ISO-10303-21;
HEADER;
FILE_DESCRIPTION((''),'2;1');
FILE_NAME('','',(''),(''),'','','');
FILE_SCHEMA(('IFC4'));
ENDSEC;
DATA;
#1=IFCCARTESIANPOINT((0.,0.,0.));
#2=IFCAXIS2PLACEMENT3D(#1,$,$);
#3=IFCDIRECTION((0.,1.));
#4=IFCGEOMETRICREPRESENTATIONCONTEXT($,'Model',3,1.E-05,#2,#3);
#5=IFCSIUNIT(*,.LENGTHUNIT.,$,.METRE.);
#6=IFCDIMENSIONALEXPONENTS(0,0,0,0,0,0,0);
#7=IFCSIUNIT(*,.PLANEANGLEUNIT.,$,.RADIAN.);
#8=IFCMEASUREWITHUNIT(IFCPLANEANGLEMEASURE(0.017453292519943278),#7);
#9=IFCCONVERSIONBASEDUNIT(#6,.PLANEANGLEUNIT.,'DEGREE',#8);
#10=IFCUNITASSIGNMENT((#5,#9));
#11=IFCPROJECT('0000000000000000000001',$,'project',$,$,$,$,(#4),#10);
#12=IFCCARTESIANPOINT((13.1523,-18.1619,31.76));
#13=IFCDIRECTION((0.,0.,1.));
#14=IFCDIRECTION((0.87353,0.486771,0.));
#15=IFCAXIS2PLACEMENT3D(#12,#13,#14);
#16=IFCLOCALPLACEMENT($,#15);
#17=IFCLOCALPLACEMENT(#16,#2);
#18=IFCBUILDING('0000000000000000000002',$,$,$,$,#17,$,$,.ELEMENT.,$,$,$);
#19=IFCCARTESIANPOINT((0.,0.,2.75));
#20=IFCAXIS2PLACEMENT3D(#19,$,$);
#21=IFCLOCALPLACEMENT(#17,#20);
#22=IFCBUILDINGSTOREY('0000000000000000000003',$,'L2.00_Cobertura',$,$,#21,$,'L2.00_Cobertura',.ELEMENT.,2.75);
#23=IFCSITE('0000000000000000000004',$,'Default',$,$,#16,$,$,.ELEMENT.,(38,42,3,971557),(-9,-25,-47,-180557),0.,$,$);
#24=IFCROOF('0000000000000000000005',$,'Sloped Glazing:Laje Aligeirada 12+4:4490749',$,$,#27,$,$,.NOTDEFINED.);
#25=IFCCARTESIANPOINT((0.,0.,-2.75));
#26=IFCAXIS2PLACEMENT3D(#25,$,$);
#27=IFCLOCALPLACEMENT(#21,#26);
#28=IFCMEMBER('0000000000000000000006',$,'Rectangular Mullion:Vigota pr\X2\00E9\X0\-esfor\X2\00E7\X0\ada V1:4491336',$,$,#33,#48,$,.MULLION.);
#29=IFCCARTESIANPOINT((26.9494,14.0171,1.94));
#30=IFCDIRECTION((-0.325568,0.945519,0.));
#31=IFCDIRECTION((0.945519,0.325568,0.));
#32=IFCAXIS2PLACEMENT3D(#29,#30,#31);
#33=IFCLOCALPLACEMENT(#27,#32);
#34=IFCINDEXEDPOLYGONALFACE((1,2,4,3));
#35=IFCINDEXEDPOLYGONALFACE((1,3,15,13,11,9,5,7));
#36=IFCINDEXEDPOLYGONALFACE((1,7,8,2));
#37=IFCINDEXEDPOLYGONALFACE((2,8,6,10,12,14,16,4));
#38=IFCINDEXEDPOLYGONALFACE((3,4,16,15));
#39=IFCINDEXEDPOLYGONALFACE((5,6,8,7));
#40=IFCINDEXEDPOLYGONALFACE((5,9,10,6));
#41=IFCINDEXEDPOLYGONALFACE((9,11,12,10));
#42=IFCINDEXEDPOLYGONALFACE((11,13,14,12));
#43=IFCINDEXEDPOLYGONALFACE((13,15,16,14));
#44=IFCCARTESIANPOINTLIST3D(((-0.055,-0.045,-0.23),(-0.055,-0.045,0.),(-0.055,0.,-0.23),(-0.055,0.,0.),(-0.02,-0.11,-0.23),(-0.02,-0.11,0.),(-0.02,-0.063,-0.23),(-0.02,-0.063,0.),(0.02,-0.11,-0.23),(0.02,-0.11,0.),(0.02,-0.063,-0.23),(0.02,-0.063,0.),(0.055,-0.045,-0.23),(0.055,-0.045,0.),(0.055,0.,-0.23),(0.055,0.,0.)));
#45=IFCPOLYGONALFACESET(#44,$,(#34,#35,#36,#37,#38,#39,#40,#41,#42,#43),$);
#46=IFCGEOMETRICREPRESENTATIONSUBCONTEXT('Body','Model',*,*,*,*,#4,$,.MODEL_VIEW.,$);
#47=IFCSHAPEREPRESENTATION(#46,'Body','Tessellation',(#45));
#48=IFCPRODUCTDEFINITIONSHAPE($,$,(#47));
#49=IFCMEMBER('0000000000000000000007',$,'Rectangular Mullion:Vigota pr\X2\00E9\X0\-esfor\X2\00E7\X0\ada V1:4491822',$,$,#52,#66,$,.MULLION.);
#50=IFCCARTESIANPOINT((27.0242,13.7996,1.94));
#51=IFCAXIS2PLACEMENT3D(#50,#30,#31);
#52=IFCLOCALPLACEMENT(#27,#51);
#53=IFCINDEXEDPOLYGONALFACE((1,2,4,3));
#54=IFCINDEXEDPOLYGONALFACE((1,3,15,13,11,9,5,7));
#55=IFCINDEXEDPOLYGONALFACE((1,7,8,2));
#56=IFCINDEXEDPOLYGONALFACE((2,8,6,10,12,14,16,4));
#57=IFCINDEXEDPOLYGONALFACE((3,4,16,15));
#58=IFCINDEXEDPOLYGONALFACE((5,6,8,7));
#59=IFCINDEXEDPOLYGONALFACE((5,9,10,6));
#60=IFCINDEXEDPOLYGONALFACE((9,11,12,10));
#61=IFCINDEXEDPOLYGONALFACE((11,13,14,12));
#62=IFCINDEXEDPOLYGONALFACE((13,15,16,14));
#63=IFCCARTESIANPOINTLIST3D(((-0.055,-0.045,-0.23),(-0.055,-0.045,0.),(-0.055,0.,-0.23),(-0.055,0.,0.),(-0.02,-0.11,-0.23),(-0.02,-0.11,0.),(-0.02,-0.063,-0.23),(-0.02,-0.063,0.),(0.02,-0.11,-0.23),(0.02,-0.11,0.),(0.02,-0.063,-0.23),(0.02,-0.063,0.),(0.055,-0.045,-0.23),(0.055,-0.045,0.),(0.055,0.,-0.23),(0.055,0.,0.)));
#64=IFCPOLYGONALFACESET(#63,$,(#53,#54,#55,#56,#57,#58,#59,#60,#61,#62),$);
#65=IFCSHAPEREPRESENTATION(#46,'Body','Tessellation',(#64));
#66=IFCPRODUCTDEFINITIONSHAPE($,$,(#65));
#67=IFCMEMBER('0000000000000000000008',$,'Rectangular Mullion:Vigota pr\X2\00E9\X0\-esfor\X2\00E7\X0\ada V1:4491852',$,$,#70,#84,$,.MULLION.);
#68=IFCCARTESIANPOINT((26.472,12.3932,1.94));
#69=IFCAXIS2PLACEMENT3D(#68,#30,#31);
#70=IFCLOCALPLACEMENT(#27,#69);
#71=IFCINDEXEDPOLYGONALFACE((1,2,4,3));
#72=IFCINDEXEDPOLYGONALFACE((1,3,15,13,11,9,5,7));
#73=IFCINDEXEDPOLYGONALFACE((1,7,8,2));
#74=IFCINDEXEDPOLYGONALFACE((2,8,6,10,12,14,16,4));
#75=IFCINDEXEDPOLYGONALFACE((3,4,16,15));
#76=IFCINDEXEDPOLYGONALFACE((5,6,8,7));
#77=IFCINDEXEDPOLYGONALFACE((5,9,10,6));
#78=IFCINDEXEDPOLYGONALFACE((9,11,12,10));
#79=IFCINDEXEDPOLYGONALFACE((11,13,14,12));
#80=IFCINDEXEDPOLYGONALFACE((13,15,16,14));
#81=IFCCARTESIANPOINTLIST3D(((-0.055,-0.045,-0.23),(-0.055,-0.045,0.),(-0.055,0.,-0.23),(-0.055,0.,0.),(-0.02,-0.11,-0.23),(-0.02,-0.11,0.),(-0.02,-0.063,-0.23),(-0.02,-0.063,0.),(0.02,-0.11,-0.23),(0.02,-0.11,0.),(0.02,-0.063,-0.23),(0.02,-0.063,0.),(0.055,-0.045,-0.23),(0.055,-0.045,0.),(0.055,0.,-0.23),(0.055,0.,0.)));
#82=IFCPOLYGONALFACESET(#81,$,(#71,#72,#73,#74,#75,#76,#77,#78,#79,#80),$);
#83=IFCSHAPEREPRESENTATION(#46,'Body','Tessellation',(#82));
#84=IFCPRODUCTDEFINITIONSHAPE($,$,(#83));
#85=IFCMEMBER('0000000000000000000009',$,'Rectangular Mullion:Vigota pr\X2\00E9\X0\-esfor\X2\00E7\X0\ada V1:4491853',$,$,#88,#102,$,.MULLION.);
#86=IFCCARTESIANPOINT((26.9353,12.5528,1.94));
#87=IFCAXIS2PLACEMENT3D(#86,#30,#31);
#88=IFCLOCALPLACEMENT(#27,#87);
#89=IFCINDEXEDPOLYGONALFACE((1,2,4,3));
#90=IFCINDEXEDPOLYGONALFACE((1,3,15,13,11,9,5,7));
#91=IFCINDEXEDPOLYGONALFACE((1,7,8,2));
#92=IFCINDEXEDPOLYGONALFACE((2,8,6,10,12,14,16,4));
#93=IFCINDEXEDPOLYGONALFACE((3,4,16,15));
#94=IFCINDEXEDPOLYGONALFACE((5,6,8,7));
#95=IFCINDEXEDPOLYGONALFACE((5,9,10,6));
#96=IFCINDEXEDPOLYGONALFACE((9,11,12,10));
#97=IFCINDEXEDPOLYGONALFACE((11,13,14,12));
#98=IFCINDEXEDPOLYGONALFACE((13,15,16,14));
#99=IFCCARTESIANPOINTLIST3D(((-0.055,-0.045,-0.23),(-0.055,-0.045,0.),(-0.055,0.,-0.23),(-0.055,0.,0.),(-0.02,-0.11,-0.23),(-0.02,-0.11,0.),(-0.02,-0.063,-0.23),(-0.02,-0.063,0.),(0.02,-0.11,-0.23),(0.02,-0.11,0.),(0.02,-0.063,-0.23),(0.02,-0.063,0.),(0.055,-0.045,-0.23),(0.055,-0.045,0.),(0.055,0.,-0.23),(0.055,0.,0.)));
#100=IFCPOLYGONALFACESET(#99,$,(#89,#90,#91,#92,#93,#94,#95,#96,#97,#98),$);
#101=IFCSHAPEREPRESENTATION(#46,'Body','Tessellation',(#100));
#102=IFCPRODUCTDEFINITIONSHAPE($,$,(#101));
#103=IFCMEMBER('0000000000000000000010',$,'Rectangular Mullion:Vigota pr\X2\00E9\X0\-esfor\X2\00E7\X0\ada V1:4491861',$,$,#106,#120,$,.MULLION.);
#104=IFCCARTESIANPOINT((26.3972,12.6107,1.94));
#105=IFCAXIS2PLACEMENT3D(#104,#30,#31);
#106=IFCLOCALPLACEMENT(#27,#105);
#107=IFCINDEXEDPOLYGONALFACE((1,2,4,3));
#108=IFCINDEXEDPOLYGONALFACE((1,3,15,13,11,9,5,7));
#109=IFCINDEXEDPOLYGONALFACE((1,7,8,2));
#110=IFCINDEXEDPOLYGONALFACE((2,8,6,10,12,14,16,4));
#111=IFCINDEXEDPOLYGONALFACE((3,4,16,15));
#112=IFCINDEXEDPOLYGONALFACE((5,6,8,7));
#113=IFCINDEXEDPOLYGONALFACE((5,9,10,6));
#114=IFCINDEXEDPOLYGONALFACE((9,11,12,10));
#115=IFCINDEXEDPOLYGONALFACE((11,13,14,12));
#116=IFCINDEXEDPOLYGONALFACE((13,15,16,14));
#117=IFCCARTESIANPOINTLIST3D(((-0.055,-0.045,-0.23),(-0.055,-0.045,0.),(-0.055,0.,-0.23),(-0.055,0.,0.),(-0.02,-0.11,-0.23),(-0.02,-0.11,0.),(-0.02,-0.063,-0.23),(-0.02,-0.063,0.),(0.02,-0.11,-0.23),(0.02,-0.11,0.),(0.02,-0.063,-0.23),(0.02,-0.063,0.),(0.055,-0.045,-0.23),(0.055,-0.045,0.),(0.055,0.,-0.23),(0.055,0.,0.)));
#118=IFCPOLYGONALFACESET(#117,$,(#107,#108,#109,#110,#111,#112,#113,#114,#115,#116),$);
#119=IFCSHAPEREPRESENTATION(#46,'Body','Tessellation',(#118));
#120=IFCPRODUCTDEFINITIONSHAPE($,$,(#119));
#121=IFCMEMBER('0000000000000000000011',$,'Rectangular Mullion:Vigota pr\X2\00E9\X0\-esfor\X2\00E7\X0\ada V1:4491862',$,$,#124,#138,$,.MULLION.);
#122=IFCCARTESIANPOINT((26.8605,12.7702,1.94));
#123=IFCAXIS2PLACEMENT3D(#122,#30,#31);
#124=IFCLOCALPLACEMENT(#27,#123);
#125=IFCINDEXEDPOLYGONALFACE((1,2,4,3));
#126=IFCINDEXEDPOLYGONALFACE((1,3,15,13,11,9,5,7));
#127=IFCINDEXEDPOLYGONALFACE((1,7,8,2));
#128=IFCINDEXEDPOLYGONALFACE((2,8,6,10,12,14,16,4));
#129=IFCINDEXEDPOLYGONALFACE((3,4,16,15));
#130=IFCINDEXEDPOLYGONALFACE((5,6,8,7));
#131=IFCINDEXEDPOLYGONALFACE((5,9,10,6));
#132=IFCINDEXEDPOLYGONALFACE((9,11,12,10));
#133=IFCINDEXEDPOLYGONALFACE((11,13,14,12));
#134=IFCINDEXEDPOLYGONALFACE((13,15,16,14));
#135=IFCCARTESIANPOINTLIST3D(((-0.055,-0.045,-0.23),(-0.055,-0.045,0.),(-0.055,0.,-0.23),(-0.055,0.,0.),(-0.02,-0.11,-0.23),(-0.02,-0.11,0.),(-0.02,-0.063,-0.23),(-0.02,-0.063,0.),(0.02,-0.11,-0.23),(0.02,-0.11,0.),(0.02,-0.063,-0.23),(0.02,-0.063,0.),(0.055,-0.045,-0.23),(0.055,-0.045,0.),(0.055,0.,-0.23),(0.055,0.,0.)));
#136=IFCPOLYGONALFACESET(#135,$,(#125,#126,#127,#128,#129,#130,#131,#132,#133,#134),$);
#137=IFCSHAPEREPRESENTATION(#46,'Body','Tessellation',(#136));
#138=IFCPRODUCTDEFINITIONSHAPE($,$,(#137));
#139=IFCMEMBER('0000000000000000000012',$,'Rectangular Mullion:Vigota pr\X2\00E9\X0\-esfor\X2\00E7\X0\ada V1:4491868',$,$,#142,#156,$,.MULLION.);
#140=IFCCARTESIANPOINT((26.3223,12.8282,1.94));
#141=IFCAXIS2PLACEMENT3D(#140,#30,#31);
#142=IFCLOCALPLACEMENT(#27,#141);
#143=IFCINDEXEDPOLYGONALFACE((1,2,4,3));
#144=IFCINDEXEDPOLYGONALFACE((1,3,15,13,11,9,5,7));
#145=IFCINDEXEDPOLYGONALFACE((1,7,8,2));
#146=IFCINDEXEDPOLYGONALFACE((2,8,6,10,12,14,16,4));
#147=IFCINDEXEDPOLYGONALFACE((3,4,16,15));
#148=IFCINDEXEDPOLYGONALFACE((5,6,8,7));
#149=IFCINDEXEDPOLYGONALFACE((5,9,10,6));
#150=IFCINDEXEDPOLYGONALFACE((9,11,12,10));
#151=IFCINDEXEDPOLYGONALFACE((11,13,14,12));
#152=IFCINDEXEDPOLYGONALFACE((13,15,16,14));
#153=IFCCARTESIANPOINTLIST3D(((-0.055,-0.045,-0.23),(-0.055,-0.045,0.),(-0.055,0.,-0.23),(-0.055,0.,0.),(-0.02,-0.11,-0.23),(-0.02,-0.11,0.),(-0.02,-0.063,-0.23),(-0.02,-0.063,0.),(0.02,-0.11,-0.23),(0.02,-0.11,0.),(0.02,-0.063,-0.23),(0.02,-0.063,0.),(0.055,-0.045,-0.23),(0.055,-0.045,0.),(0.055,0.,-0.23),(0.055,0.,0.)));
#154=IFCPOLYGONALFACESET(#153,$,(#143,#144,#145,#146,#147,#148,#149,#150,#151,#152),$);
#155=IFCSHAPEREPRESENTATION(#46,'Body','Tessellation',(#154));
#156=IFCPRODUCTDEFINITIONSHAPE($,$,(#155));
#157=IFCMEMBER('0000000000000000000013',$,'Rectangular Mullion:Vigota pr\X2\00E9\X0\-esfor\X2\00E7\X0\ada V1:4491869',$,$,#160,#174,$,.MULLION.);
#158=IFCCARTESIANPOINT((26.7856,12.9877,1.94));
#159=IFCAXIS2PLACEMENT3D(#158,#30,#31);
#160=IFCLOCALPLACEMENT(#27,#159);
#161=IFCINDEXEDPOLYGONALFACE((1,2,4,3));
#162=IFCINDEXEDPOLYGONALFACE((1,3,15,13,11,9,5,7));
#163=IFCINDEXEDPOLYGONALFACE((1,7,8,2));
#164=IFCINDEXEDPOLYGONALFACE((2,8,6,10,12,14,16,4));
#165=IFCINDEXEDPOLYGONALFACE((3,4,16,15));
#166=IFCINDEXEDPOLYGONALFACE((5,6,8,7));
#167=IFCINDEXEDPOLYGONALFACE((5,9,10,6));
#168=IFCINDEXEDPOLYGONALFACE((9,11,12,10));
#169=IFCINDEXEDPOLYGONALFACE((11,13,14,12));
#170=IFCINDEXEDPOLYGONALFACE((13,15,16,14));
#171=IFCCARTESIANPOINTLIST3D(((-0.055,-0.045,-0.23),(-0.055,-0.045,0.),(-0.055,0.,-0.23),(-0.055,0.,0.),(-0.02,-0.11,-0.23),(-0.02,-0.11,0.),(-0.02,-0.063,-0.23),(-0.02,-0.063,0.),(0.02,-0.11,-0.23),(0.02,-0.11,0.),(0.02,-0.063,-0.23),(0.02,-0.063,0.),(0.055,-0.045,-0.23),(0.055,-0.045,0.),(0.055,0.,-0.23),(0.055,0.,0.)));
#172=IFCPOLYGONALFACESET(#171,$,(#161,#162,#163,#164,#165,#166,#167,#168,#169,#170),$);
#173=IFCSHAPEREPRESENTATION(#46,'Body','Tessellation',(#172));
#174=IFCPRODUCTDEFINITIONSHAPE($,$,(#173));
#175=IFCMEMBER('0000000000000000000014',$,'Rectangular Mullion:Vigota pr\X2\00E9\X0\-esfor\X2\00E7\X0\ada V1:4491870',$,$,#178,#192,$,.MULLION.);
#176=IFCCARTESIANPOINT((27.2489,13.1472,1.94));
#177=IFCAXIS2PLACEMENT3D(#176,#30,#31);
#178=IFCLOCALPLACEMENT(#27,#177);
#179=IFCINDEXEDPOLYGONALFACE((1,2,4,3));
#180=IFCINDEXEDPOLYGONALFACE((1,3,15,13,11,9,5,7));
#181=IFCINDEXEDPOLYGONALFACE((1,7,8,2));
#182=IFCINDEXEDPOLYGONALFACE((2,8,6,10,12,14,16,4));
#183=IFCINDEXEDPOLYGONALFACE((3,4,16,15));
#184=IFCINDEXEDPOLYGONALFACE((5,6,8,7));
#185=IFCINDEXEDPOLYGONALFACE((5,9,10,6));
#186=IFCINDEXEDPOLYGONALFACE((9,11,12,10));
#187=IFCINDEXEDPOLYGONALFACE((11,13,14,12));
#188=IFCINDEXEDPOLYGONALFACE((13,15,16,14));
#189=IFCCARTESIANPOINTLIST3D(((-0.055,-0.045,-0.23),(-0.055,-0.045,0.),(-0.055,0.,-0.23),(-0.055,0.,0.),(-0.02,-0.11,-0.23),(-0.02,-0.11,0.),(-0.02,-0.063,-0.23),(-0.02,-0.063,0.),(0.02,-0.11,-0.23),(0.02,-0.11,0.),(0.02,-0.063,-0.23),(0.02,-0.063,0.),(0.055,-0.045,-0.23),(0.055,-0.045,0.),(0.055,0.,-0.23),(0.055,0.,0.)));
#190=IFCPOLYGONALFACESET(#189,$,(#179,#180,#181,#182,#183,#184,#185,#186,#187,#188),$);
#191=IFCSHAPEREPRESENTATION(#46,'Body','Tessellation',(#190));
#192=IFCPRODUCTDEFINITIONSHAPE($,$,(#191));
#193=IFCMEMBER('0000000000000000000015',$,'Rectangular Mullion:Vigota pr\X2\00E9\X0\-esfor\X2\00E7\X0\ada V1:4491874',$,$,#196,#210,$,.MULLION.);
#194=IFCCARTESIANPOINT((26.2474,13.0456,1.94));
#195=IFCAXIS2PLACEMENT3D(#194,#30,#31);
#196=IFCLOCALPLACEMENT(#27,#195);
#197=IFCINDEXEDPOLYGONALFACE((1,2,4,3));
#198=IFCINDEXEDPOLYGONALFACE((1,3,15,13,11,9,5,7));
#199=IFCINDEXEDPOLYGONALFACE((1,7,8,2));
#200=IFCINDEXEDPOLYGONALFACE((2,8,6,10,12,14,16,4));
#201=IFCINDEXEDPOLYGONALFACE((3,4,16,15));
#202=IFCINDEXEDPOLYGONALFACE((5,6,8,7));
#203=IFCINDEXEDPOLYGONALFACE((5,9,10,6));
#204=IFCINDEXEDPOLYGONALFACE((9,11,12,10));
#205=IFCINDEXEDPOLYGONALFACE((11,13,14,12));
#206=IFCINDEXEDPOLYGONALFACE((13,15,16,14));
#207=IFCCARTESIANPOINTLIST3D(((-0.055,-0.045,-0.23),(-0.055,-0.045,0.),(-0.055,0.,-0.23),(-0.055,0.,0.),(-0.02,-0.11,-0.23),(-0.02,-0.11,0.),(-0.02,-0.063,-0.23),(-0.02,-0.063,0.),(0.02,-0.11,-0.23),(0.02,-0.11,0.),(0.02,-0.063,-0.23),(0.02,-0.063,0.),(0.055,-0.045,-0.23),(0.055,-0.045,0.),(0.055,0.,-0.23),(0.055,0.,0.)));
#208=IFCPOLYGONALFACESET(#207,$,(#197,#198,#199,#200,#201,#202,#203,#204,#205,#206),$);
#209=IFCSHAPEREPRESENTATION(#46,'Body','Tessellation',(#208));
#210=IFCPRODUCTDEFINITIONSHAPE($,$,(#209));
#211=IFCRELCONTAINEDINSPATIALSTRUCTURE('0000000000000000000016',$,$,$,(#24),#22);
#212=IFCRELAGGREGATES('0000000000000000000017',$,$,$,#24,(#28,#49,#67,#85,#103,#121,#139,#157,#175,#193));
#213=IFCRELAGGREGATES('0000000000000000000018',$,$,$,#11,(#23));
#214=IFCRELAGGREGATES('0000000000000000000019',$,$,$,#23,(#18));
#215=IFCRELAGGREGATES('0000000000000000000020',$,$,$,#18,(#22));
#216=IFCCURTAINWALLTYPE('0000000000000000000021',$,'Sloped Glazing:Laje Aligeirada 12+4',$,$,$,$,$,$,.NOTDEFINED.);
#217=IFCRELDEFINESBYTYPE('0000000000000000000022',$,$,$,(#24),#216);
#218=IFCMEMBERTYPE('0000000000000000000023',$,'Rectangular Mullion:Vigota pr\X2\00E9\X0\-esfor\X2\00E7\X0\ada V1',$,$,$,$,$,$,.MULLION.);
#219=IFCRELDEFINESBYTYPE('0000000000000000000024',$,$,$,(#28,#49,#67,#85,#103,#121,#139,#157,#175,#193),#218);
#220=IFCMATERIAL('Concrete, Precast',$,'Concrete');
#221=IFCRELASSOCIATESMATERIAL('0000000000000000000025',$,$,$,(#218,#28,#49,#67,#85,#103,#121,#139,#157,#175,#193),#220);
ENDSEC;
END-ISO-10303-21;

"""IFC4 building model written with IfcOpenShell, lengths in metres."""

from ifc_helpers import new_model, entity, si_unit, converted_unit, direction, frame, origin, place, context, subcontext, project, spatial, indexed_curve, outline, extrude, source, transform, mapped, material, type_object, type_shapes, element, aggregate, save


model = new_model("IFC4")

# Units and contexts
model_context = context("Model", 3, precision=1e-05, world=origin(), true_north=direction((0.0, 1.0)))
body_context = subcontext(model_context, "Body", "Model", "MODEL_VIEW")
ifc_project = project(units=[si_unit("LENGTHUNIT", "METRE"), converted_unit("PLANEANGLEUNIT", "DEGREE", entity("IfcPlaneAngleMeasure", 0.017453292519943278), si_unit("PLANEANGLEUNIT", "RADIAN"), dimensions=[0, 0, 0, 0, 0, 0, 0])], contexts=[model_context])

# Site, building, storey
site_placement = place(None, frame((13.1523, -18.1619, 31.76), z_axis=(0.0, 0.0, 1.0), x_axis=(0.87353, 0.486771, 0.0)))
site = spatial("IfcSite", under=ifc_project, at=site_placement, Name="Default", CompositionType="ELEMENT", RefLatitude=(38, 42, 3, 971557), RefLongitude=(-9, -25, -47, -180557), RefElevation=0.0)
building_placement = place(site_placement, origin())
building = spatial("IfcBuilding", under=site, at=building_placement, CompositionType="ELEMENT")
storey_placement = place(building_placement, frame((0.0, 0.0, 2.75)))
storey = spatial("IfcBuildingStorey", under=building, at=storey_placement, Name="L2.00_Cobertura", LongName="L2.00_Cobertura", CompositionType="ELEMENT", Elevation=2.75)

# Roof, members
curtain_wall_type = type_object("IfcCurtainWallType", Name="Sloped Glazing:Laje Aligeirada 12+4", PredefinedType="NOTDEFINED")
roof_placement = place(storey_placement, frame((0.0, 0.0, -2.75)))
roof = element("IfcRoof", 1, at=roof_placement, inside=storey, type_object=curtain_wall_type, Name="Sloped Glazing:Laje Aligeirada 12+4:4490749", PredefinedType="NOTDEFINED")
ifc_material_1 = material(Name="Concrete, Precast", Category="Concrete")
member_type = type_object("IfcMemberType", Name="Rectangular Mullion:Vigota pré-esforçada V1", PredefinedType="MULLION", material=ifc_material_1)
shared_shape_1 = source(origin(), body_context, "Body", "SweptSolid", [
    extrude(outline(indexed_curve([(-0.055, -0.0545), (0.055, -0.0545), (0.055, -0.0095), (0.02, 0.0085), (0.02, 0.0555), (-0.02, 0.0555), (-0.02, 0.0085), (-0.055, -0.0095), (-0.055, -0.0545)], self_intersect=False)), frame((0.0, -0.0545, -0.23), z_axis=(0.0, 0.0, 1.0), x_axis=(-1.0, 0.0, 0.0)), (0.0, 0.0, 1.0), 0.23),
])
type_shapes(member_type, [shared_shape_1])
member_1_placement = place(roof_placement, frame((26.9494, 14.0171, 1.94), z_axis=(-0.325568, 0.945519, 0.0), x_axis=(0.945519, 0.325568, 0.0)))
member_1 = element("IfcMember", 2, at=member_1_placement, type_object=member_type, material=ifc_material_1, Name="Rectangular Mullion:Vigota pré-esforçada V1:4491336", PredefinedType="MULLION", context=body_context, shape_type="MappedRepresentation", body=[
    mapped(shared_shape_1, transform((0.0, 0.0, 0.0), scale=1.0)),
])
member_2_placement = place(roof_placement, frame((27.0242, 13.7996, 1.94), z_axis=(-0.325568, 0.945519, 0.0), x_axis=(0.945519, 0.325568, 0.0)))
member_2 = element("IfcMember", 3, at=member_2_placement, type_object=member_type, material=ifc_material_1, Name="Rectangular Mullion:Vigota pré-esforçada V1:4491822", PredefinedType="MULLION", context=body_context, shape_type="MappedRepresentation", body=[
    mapped(shared_shape_1, transform((0.0, 0.0, 0.0), scale=1.0)),
])
member_3_placement = place(roof_placement, frame((26.472, 12.3932, 1.94), z_axis=(-0.325568, 0.945519, 0.0), x_axis=(0.945519, 0.325568, 0.0)))
member_3 = element("IfcMember", 4, at=member_3_placement, type_object=member_type, material=ifc_material_1, Name="Rectangular Mullion:Vigota pré-esforçada V1:4491852", PredefinedType="MULLION", context=body_context, shape_type="MappedRepresentation", body=[
    mapped(shared_shape_1, transform((0.0, 0.0, 0.0), scale=1.0)),
])
member_4_placement = place(roof_placement, frame((26.9353, 12.5528, 1.94), z_axis=(-0.325568, 0.945519, 0.0), x_axis=(0.945519, 0.325568, 0.0)))
member_4 = element("IfcMember", 5, at=member_4_placement, type_object=member_type, material=ifc_material_1, Name="Rectangular Mullion:Vigota pré-esforçada V1:4491853", PredefinedType="MULLION", context=body_context, shape_type="MappedRepresentation", body=[
    mapped(shared_shape_1, transform((0.0, 0.0, 0.0), scale=1.0)),
])
member_5_placement = place(roof_placement, frame((26.3972, 12.6107, 1.94), z_axis=(-0.325568, 0.945519, 0.0), x_axis=(0.945519, 0.325568, 0.0)))
member_5 = element("IfcMember", 6, at=member_5_placement, type_object=member_type, material=ifc_material_1, Name="Rectangular Mullion:Vigota pré-esforçada V1:4491861", PredefinedType="MULLION", context=body_context, shape_type="MappedRepresentation", body=[
    mapped(shared_shape_1, transform((0.0, 0.0, 0.0), scale=1.0)),
])
member_6_placement = place(roof_placement, frame((26.8605, 12.7702, 1.94), z_axis=(-0.325568, 0.945519, 0.0), x_axis=(0.945519, 0.325568, 0.0)))
member_6 = element("IfcMember", 7, at=member_6_placement, type_object=member_type, material=ifc_material_1, Name="Rectangular Mullion:Vigota pré-esforçada V1:4491862", PredefinedType="MULLION", context=body_context, shape_type="MappedRepresentation", body=[
    mapped(shared_shape_1, transform((0.0, 0.0, 0.0), scale=1.0)),
])
member_7_placement = place(roof_placement, frame((26.3223, 12.8282, 1.94), z_axis=(-0.325568, 0.945519, 0.0), x_axis=(0.945519, 0.325568, 0.0)))
member_7 = element("IfcMember", 8, at=member_7_placement, type_object=member_type, material=ifc_material_1, Name="Rectangular Mullion:Vigota pré-esforçada V1:4491868", PredefinedType="MULLION", context=body_context, shape_type="MappedRepresentation", body=[
    mapped(shared_shape_1, transform((0.0, 0.0, 0.0), scale=1.0)),
])
member_8_placement = place(roof_placement, frame((26.7856, 12.9877, 1.94), z_axis=(-0.325568, 0.945519, 0.0), x_axis=(0.945519, 0.325568, 0.0)))
member_8 = element("IfcMember", 9, at=member_8_placement, type_object=member_type, material=ifc_material_1, Name="Rectangular Mullion:Vigota pré-esforçada V1:4491869", PredefinedType="MULLION", context=body_context, shape_type="MappedRepresentation", body=[
    mapped(shared_shape_1, transform((0.0, 0.0, 0.0), scale=1.0)),
])
member_9_placement = place(roof_placement, frame((27.2489, 13.1472, 1.94), z_axis=(-0.325568, 0.945519, 0.0), x_axis=(0.945519, 0.325568, 0.0)))
member_9 = element("IfcMember", 10, at=member_9_placement, type_object=member_type, material=ifc_material_1, Name="Rectangular Mullion:Vigota pré-esforçada V1:4491870", PredefinedType="MULLION", context=body_context, shape_type="MappedRepresentation", body=[
    mapped(shared_shape_1, transform((0.0, 0.0, 0.0), scale=1.0)),
])
member_10_placement = place(roof_placement, frame((26.2474, 13.0456, 1.94), z_axis=(-0.325568, 0.945519, 0.0), x_axis=(0.945519, 0.325568, 0.0)))
member_10 = element("IfcMember", 11, at=member_10_placement, type_object=member_type, material=ifc_material_1, Name="Rectangular Mullion:Vigota pré-esforçada V1:4491874", PredefinedType="MULLION", context=body_context, shape_type="MappedRepresentation", body=[
    mapped(shared_shape_1, transform((0.0, 0.0, 0.0), scale=1.0)),
])
aggregate(roof, [member_1, member_2, member_3, member_4, member_5, member_6, member_7, member_8, member_9, member_10])

save(model, "model.ifc")
